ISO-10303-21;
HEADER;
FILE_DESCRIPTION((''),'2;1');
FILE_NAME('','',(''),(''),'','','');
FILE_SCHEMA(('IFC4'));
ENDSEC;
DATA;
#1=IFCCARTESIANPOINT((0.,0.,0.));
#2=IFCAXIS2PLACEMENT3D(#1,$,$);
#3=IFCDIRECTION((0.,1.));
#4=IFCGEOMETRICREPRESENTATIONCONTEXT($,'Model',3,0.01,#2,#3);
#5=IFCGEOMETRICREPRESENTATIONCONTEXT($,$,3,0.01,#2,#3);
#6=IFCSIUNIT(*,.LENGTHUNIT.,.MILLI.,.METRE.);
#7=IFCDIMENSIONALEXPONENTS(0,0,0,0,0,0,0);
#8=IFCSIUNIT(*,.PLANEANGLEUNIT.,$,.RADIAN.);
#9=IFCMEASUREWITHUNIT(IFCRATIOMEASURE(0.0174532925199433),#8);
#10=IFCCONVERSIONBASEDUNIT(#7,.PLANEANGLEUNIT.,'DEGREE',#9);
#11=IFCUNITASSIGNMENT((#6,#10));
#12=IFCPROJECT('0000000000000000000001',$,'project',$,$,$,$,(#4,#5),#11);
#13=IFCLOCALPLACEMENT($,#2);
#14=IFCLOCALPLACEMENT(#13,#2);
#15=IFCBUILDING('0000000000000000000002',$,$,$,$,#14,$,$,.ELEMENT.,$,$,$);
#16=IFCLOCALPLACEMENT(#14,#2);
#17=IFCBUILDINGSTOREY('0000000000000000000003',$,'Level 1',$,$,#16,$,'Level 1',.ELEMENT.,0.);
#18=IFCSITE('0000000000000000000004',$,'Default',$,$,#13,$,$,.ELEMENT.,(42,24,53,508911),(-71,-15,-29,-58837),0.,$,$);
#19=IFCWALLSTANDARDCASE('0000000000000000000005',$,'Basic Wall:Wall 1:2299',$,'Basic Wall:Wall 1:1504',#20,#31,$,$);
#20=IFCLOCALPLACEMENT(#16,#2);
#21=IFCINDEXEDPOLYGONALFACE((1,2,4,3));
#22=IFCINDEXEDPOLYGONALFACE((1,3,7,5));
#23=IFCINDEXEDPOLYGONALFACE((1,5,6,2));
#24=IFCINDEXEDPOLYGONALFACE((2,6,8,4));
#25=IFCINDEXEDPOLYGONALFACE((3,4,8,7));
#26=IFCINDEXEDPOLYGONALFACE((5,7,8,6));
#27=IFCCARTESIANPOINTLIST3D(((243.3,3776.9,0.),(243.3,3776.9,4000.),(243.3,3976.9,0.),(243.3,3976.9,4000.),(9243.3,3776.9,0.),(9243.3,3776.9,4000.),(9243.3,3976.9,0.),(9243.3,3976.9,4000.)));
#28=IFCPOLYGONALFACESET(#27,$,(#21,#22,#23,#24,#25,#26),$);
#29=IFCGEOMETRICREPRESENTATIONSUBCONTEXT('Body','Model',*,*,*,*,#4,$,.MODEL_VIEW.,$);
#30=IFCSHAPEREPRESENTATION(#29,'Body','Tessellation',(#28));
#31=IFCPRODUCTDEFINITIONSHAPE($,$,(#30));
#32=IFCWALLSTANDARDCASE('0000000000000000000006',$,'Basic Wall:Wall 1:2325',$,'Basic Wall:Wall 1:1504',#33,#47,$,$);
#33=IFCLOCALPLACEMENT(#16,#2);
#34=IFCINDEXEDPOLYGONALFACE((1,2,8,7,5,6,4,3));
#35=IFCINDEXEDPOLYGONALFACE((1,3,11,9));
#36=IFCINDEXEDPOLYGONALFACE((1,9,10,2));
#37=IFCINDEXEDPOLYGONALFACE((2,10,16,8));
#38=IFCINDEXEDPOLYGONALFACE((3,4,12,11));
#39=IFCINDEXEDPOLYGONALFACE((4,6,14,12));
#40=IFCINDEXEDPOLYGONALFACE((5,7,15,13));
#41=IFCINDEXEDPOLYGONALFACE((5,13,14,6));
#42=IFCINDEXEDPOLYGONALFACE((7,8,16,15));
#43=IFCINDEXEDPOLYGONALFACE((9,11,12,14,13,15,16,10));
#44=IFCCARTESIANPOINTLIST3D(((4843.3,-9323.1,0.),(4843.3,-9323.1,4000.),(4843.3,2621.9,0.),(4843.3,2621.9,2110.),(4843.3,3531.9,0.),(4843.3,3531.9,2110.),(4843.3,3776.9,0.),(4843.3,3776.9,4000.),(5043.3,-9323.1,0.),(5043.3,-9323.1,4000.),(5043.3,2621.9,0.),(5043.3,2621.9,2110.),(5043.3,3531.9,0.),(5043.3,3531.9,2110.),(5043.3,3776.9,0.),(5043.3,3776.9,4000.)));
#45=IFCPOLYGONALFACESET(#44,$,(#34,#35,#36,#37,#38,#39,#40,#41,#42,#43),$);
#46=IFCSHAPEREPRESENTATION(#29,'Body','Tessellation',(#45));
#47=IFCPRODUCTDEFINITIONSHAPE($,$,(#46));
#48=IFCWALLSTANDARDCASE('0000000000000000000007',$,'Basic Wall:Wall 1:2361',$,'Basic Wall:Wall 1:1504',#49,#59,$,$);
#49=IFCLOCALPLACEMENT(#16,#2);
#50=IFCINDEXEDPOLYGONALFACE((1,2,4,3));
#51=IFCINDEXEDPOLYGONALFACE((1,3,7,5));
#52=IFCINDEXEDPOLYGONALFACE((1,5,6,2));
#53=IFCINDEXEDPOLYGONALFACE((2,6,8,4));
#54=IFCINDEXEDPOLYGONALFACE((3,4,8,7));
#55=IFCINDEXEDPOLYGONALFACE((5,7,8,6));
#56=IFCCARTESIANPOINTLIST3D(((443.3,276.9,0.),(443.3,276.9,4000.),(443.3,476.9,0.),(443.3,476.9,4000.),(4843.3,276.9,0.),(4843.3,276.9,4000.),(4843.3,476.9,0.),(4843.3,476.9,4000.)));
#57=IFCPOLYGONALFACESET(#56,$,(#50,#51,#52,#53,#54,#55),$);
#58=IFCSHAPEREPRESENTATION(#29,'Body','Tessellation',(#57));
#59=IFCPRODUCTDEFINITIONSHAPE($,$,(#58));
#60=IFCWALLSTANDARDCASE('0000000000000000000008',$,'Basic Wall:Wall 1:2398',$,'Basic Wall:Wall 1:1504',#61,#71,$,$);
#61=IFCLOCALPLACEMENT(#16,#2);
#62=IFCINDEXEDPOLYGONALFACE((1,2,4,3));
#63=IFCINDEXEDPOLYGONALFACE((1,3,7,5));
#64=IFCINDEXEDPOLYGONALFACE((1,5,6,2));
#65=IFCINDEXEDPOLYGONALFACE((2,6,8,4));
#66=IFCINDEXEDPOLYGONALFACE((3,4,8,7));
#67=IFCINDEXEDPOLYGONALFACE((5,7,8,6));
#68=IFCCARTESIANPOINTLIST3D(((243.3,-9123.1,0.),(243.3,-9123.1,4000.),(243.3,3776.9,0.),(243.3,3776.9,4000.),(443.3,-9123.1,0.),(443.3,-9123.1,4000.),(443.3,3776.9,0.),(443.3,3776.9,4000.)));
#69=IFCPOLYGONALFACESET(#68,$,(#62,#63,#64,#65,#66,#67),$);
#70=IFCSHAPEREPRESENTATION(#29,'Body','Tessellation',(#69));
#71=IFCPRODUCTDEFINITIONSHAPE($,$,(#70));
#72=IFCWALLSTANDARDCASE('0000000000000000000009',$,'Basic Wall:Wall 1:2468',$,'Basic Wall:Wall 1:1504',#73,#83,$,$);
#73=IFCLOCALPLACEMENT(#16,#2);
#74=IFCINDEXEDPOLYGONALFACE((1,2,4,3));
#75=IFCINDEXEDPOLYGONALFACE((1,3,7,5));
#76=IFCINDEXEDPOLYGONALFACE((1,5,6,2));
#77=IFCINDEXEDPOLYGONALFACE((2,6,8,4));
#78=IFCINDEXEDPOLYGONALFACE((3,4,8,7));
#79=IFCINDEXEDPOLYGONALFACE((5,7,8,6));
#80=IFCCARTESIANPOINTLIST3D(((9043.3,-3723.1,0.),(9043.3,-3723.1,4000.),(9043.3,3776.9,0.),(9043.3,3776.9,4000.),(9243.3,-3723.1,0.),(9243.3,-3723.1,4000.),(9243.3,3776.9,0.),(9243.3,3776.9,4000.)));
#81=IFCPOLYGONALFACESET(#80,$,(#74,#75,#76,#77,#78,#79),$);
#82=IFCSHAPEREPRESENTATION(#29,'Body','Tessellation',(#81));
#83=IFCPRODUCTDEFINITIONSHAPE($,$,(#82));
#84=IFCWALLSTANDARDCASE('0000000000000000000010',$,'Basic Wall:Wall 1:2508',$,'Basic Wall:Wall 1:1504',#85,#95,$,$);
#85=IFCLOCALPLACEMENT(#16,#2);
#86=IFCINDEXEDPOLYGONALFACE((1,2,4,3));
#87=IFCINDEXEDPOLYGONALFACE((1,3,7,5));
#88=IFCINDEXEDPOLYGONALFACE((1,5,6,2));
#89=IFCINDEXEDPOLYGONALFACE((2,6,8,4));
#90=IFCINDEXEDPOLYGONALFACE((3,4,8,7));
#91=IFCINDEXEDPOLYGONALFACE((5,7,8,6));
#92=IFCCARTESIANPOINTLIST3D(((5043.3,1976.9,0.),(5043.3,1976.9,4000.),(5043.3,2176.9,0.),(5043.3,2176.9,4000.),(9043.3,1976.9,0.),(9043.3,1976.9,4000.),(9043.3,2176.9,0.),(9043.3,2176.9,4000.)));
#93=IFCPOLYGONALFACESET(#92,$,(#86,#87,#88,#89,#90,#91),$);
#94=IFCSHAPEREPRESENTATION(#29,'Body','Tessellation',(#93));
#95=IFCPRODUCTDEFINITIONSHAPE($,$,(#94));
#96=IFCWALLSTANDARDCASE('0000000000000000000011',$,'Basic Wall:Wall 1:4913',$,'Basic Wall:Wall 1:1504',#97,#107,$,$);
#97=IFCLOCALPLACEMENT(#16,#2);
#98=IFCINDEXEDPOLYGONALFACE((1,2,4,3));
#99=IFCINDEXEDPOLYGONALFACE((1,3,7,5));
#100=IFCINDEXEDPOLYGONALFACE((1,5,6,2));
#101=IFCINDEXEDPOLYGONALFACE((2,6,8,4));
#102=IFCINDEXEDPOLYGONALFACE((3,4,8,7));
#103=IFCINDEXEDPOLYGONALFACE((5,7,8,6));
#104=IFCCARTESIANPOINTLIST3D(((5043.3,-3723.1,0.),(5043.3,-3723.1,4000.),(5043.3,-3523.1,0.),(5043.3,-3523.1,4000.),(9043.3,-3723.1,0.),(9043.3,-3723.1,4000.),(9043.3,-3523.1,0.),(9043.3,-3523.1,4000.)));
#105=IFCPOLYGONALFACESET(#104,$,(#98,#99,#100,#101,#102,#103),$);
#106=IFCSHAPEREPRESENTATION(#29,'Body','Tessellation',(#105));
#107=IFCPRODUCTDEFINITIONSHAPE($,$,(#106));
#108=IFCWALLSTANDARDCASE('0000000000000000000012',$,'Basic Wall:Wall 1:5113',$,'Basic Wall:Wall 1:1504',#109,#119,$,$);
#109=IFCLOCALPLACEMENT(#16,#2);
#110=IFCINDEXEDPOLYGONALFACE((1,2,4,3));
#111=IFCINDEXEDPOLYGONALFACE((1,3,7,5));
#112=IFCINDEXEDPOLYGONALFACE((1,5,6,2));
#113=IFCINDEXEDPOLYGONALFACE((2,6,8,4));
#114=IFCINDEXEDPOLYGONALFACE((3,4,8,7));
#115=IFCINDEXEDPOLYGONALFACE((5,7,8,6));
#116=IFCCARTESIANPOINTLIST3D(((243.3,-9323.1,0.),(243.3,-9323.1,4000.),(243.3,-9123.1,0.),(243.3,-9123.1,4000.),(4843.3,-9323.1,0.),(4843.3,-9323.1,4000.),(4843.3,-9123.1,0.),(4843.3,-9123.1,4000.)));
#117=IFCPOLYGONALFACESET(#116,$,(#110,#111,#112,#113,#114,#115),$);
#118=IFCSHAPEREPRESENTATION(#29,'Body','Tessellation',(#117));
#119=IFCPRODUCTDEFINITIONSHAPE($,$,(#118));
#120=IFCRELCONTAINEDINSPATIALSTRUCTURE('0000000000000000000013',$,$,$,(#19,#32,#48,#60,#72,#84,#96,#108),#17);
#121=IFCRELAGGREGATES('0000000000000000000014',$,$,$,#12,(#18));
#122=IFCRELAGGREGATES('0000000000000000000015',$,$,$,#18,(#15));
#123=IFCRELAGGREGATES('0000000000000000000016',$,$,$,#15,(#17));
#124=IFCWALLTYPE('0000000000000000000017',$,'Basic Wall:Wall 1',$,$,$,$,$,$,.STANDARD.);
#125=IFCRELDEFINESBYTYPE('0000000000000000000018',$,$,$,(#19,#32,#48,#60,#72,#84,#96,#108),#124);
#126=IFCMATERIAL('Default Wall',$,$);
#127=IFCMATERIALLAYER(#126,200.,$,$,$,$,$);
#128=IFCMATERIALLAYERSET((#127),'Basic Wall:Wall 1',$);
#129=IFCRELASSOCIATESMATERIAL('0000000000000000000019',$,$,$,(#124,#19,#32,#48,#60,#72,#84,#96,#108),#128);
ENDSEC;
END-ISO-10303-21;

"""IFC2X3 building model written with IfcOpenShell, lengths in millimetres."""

from ifc_helpers import new_model, entity, si_unit, converted_unit, direction, frame, frame_2d, origin, place, context, subcontext, project, spatial, rectangle, extrude, material, layer, layer_set, layer_usage, type_object, element, save


model = new_model("IFC2X3")

# Units and contexts
model_context = context("Model", 3, precision=0.01, world=origin(), true_north=direction((0.0, 1.0)))
context_of_model = context(None, 3, precision=0.01, world=origin(), true_north=direction((0.0, 1.0)))
body_context = subcontext(model_context, "Body", "Model", "MODEL_VIEW")
ifc_project = project(units=[si_unit("LENGTHUNIT", "METRE", prefix="MILLI"), converted_unit("PLANEANGLEUNIT", "DEGREE", entity("IfcRatioMeasure", 0.0174532925199433), si_unit("PLANEANGLEUNIT", "RADIAN"), dimensions=[0, 0, 0, 0, 0, 0, 0])], contexts=[model_context, context_of_model])

# Site, building, storey
site_placement = place(None, origin())
site = spatial("IfcSite", under=ifc_project, at=site_placement, Name="Default", CompositionType="ELEMENT", RefLatitude=(42, 24, 53, 508911), RefLongitude=(-71, -15, -29, -58837), RefElevation=0.0)
building_placement = place(site_placement, origin())
building = spatial("IfcBuilding", under=site, at=building_placement, CompositionType="ELEMENT")
storey_placement = place(building_placement, origin())
storey = spatial("IfcBuildingStorey", under=building, at=storey_placement, Name="Level 1", LongName="Level 1", CompositionType="ELEMENT", Elevation=0.0)

# Wall
ifc_material = material(Name="Default Wall")
ifc_layer = layer(ifc_material, 200.0)
ifc_layer_set = layer_set([ifc_layer], Name="Basic Wall:Wall 1")
ifc_layer_usage_1 = layer_usage(ifc_layer_set, "AXIS2", "NEGATIVE", 100.0)
wall_type = type_object("IfcWallType", Name="Basic Wall:Wall 1", PredefinedType="STANDARD", material=ifc_layer_set)
wall_1_placement = place(storey_placement, frame((243.3, 3876.9, 0.0)))
element("IfcWallStandardCase", 1, at=wall_1_placement, inside=storey, type_object=wall_type, material=ifc_layer_usage_1, Name="Basic Wall:Wall 1:2299", ObjectType="Basic Wall:Wall 1:1504", context=body_context, shape_type="SweptSolid", body=[
    extrude(rectangle(XDim=9000.0, YDim=200.0, at=frame_2d((4500.0, 0.0), x_axis=(-1.0, 0.0))), origin(), (0.0, 0.0, 1.0), 4000.0),
])

# Wall, opening
ifc_layer_usage_2 = layer_usage(ifc_layer_set, "AXIS2", "NEGATIVE", 100.0)
wall_2_placement = place(storey_placement, frame((4943.3, 3776.9, 0.0), z_axis=(0.0, 0.0, 1.0), x_axis=(0.0, -1.0, 0.0)))
wall_2 = element("IfcWallStandardCase", 2, at=wall_2_placement, inside=storey, type_object=wall_type, material=ifc_layer_usage_2, Name="Basic Wall:Wall 1:2325", ObjectType="Basic Wall:Wall 1:1504", context=body_context, shape_type="SweptSolid", body=[
    extrude(rectangle(XDim=13100.0, YDim=200.0, at=frame_2d((6550.0, 0.0), x_axis=(-1.0, 0.0))), origin(), (0.0, 0.0, 1.0), 4000.0),
])
opening_placement = place(wall_2_placement, frame((245.0, -100.0, 0.0)))
element("IfcOpeningElement", 3, at=opening_placement, cuts=wall_2, ObjectType="Opening", context=body_context, shape_type="SweptSolid", body=[
    extrude(rectangle(XDim=2110.0, YDim=910.0, at=frame_2d((1055.0, 455.0), x_axis=(-1.0, 0.0))), frame((0.0, 0.0, 0.0), z_axis=(0.0, 1.0, 0.0), x_axis=(0.0, 0.0, 1.0)), (0.0, 0.0, 1.0), 200.0),
])

# Walls
ifc_layer_usage_3 = layer_usage(ifc_layer_set, "AXIS2", "NEGATIVE", 100.0)
wall_3_placement = place(storey_placement, frame((4843.3, 376.9, 0.0), z_axis=(0.0, 0.0, 1.0), x_axis=(-1.0, 0.0, 0.0)))
element("IfcWallStandardCase", 4, at=wall_3_placement, inside=storey, type_object=wall_type, material=ifc_layer_usage_3, Name="Basic Wall:Wall 1:2361", ObjectType="Basic Wall:Wall 1:1504", context=body_context, shape_type="SweptSolid", body=[
    extrude(rectangle(XDim=4400.0, YDim=200.0, at=frame_2d((2200.0, 0.0), x_axis=(-1.0, 0.0))), origin(), (0.0, 0.0, 1.0), 4000.0),
])
ifc_layer_usage_4 = layer_usage(ifc_layer_set, "AXIS2", "NEGATIVE", 100.0)
wall_4_placement = place(storey_placement, frame((343.3, -9123.1, 0.0), z_axis=(0.0, 0.0, 1.0), x_axis=(0.0, 1.0, 0.0)))
element("IfcWallStandardCase", 5, at=wall_4_placement, inside=storey, type_object=wall_type, material=ifc_layer_usage_4, Name="Basic Wall:Wall 1:2398", ObjectType="Basic Wall:Wall 1:1504", context=body_context, shape_type="SweptSolid", body=[
    extrude(rectangle(XDim=12900.0, YDim=200.0, at=frame_2d((6450.0, 0.0), x_axis=(-1.0, 0.0))), origin(), (0.0, 0.0, 1.0), 4000.0),
])
ifc_layer_usage_5 = layer_usage(ifc_layer_set, "AXIS2", "NEGATIVE", 100.0)
wall_5_placement = place(storey_placement, frame((9143.3, 3776.9, 0.0), z_axis=(0.0, 0.0, 1.0), x_axis=(0.0, -1.0, 0.0)))
element("IfcWallStandardCase", 6, at=wall_5_placement, inside=storey, type_object=wall_type, material=ifc_layer_usage_5, Name="Basic Wall:Wall 1:2468", ObjectType="Basic Wall:Wall 1:1504", context=body_context, shape_type="SweptSolid", body=[
    extrude(rectangle(XDim=7500.0, YDim=200.0, at=frame_2d((3750.0, 0.0), x_axis=(-1.0, 0.0))), origin(), (0.0, 0.0, 1.0), 4000.0),
])
ifc_layer_usage_6 = layer_usage(ifc_layer_set, "AXIS2", "NEGATIVE", 100.0)
wall_6_placement = place(storey_placement, frame((9043.3, 2076.9, 0.0), z_axis=(0.0, 0.0, 1.0), x_axis=(-1.0, 0.0, 0.0)))
element("IfcWallStandardCase", 7, at=wall_6_placement, inside=storey, type_object=wall_type, material=ifc_layer_usage_6, Name="Basic Wall:Wall 1:2508", ObjectType="Basic Wall:Wall 1:1504", context=body_context, shape_type="SweptSolid", body=[
    extrude(rectangle(XDim=4000.0, YDim=200.0, at=frame_2d((2000.0, 0.0), x_axis=(-1.0, 0.0))), origin(), (0.0, 0.0, 1.0), 4000.0),
])
ifc_layer_usage_7 = layer_usage(ifc_layer_set, "AXIS2", "NEGATIVE", 100.0)
wall_7_placement = place(storey_placement, frame((9043.3, -3623.1, 0.0), z_axis=(0.0, 0.0, 1.0), x_axis=(-1.0, 0.0, 0.0)))
element("IfcWallStandardCase", 8, at=wall_7_placement, inside=storey, type_object=wall_type, material=ifc_layer_usage_7, Name="Basic Wall:Wall 1:4913", ObjectType="Basic Wall:Wall 1:1504", context=body_context, shape_type="SweptSolid", body=[
    extrude(rectangle(XDim=4000.0, YDim=200.0, at=frame_2d((2000.0, 0.0), x_axis=(-1.0, 0.0))), origin(), (0.0, 0.0, 1.0), 4000.0),
])
ifc_layer_usage_8 = layer_usage(ifc_layer_set, "AXIS2", "NEGATIVE", 100.0)
wall_8_placement = place(storey_placement, frame((4843.3, -9223.1, 0.0), z_axis=(0.0, 0.0, 1.0), x_axis=(-1.0, 0.0, 0.0)))
element("IfcWallStandardCase", 9, at=wall_8_placement, inside=storey, type_object=wall_type, material=ifc_layer_usage_8, Name="Basic Wall:Wall 1:5113", ObjectType="Basic Wall:Wall 1:1504", context=body_context, shape_type="SweptSolid", body=[
    extrude(rectangle(XDim=4600.0, YDim=200.0, at=frame_2d((2300.0, 0.0), x_axis=(-1.0, 0.0))), origin(), (0.0, 0.0, 1.0), 4000.0),
])

save(model, "model.ifc")
